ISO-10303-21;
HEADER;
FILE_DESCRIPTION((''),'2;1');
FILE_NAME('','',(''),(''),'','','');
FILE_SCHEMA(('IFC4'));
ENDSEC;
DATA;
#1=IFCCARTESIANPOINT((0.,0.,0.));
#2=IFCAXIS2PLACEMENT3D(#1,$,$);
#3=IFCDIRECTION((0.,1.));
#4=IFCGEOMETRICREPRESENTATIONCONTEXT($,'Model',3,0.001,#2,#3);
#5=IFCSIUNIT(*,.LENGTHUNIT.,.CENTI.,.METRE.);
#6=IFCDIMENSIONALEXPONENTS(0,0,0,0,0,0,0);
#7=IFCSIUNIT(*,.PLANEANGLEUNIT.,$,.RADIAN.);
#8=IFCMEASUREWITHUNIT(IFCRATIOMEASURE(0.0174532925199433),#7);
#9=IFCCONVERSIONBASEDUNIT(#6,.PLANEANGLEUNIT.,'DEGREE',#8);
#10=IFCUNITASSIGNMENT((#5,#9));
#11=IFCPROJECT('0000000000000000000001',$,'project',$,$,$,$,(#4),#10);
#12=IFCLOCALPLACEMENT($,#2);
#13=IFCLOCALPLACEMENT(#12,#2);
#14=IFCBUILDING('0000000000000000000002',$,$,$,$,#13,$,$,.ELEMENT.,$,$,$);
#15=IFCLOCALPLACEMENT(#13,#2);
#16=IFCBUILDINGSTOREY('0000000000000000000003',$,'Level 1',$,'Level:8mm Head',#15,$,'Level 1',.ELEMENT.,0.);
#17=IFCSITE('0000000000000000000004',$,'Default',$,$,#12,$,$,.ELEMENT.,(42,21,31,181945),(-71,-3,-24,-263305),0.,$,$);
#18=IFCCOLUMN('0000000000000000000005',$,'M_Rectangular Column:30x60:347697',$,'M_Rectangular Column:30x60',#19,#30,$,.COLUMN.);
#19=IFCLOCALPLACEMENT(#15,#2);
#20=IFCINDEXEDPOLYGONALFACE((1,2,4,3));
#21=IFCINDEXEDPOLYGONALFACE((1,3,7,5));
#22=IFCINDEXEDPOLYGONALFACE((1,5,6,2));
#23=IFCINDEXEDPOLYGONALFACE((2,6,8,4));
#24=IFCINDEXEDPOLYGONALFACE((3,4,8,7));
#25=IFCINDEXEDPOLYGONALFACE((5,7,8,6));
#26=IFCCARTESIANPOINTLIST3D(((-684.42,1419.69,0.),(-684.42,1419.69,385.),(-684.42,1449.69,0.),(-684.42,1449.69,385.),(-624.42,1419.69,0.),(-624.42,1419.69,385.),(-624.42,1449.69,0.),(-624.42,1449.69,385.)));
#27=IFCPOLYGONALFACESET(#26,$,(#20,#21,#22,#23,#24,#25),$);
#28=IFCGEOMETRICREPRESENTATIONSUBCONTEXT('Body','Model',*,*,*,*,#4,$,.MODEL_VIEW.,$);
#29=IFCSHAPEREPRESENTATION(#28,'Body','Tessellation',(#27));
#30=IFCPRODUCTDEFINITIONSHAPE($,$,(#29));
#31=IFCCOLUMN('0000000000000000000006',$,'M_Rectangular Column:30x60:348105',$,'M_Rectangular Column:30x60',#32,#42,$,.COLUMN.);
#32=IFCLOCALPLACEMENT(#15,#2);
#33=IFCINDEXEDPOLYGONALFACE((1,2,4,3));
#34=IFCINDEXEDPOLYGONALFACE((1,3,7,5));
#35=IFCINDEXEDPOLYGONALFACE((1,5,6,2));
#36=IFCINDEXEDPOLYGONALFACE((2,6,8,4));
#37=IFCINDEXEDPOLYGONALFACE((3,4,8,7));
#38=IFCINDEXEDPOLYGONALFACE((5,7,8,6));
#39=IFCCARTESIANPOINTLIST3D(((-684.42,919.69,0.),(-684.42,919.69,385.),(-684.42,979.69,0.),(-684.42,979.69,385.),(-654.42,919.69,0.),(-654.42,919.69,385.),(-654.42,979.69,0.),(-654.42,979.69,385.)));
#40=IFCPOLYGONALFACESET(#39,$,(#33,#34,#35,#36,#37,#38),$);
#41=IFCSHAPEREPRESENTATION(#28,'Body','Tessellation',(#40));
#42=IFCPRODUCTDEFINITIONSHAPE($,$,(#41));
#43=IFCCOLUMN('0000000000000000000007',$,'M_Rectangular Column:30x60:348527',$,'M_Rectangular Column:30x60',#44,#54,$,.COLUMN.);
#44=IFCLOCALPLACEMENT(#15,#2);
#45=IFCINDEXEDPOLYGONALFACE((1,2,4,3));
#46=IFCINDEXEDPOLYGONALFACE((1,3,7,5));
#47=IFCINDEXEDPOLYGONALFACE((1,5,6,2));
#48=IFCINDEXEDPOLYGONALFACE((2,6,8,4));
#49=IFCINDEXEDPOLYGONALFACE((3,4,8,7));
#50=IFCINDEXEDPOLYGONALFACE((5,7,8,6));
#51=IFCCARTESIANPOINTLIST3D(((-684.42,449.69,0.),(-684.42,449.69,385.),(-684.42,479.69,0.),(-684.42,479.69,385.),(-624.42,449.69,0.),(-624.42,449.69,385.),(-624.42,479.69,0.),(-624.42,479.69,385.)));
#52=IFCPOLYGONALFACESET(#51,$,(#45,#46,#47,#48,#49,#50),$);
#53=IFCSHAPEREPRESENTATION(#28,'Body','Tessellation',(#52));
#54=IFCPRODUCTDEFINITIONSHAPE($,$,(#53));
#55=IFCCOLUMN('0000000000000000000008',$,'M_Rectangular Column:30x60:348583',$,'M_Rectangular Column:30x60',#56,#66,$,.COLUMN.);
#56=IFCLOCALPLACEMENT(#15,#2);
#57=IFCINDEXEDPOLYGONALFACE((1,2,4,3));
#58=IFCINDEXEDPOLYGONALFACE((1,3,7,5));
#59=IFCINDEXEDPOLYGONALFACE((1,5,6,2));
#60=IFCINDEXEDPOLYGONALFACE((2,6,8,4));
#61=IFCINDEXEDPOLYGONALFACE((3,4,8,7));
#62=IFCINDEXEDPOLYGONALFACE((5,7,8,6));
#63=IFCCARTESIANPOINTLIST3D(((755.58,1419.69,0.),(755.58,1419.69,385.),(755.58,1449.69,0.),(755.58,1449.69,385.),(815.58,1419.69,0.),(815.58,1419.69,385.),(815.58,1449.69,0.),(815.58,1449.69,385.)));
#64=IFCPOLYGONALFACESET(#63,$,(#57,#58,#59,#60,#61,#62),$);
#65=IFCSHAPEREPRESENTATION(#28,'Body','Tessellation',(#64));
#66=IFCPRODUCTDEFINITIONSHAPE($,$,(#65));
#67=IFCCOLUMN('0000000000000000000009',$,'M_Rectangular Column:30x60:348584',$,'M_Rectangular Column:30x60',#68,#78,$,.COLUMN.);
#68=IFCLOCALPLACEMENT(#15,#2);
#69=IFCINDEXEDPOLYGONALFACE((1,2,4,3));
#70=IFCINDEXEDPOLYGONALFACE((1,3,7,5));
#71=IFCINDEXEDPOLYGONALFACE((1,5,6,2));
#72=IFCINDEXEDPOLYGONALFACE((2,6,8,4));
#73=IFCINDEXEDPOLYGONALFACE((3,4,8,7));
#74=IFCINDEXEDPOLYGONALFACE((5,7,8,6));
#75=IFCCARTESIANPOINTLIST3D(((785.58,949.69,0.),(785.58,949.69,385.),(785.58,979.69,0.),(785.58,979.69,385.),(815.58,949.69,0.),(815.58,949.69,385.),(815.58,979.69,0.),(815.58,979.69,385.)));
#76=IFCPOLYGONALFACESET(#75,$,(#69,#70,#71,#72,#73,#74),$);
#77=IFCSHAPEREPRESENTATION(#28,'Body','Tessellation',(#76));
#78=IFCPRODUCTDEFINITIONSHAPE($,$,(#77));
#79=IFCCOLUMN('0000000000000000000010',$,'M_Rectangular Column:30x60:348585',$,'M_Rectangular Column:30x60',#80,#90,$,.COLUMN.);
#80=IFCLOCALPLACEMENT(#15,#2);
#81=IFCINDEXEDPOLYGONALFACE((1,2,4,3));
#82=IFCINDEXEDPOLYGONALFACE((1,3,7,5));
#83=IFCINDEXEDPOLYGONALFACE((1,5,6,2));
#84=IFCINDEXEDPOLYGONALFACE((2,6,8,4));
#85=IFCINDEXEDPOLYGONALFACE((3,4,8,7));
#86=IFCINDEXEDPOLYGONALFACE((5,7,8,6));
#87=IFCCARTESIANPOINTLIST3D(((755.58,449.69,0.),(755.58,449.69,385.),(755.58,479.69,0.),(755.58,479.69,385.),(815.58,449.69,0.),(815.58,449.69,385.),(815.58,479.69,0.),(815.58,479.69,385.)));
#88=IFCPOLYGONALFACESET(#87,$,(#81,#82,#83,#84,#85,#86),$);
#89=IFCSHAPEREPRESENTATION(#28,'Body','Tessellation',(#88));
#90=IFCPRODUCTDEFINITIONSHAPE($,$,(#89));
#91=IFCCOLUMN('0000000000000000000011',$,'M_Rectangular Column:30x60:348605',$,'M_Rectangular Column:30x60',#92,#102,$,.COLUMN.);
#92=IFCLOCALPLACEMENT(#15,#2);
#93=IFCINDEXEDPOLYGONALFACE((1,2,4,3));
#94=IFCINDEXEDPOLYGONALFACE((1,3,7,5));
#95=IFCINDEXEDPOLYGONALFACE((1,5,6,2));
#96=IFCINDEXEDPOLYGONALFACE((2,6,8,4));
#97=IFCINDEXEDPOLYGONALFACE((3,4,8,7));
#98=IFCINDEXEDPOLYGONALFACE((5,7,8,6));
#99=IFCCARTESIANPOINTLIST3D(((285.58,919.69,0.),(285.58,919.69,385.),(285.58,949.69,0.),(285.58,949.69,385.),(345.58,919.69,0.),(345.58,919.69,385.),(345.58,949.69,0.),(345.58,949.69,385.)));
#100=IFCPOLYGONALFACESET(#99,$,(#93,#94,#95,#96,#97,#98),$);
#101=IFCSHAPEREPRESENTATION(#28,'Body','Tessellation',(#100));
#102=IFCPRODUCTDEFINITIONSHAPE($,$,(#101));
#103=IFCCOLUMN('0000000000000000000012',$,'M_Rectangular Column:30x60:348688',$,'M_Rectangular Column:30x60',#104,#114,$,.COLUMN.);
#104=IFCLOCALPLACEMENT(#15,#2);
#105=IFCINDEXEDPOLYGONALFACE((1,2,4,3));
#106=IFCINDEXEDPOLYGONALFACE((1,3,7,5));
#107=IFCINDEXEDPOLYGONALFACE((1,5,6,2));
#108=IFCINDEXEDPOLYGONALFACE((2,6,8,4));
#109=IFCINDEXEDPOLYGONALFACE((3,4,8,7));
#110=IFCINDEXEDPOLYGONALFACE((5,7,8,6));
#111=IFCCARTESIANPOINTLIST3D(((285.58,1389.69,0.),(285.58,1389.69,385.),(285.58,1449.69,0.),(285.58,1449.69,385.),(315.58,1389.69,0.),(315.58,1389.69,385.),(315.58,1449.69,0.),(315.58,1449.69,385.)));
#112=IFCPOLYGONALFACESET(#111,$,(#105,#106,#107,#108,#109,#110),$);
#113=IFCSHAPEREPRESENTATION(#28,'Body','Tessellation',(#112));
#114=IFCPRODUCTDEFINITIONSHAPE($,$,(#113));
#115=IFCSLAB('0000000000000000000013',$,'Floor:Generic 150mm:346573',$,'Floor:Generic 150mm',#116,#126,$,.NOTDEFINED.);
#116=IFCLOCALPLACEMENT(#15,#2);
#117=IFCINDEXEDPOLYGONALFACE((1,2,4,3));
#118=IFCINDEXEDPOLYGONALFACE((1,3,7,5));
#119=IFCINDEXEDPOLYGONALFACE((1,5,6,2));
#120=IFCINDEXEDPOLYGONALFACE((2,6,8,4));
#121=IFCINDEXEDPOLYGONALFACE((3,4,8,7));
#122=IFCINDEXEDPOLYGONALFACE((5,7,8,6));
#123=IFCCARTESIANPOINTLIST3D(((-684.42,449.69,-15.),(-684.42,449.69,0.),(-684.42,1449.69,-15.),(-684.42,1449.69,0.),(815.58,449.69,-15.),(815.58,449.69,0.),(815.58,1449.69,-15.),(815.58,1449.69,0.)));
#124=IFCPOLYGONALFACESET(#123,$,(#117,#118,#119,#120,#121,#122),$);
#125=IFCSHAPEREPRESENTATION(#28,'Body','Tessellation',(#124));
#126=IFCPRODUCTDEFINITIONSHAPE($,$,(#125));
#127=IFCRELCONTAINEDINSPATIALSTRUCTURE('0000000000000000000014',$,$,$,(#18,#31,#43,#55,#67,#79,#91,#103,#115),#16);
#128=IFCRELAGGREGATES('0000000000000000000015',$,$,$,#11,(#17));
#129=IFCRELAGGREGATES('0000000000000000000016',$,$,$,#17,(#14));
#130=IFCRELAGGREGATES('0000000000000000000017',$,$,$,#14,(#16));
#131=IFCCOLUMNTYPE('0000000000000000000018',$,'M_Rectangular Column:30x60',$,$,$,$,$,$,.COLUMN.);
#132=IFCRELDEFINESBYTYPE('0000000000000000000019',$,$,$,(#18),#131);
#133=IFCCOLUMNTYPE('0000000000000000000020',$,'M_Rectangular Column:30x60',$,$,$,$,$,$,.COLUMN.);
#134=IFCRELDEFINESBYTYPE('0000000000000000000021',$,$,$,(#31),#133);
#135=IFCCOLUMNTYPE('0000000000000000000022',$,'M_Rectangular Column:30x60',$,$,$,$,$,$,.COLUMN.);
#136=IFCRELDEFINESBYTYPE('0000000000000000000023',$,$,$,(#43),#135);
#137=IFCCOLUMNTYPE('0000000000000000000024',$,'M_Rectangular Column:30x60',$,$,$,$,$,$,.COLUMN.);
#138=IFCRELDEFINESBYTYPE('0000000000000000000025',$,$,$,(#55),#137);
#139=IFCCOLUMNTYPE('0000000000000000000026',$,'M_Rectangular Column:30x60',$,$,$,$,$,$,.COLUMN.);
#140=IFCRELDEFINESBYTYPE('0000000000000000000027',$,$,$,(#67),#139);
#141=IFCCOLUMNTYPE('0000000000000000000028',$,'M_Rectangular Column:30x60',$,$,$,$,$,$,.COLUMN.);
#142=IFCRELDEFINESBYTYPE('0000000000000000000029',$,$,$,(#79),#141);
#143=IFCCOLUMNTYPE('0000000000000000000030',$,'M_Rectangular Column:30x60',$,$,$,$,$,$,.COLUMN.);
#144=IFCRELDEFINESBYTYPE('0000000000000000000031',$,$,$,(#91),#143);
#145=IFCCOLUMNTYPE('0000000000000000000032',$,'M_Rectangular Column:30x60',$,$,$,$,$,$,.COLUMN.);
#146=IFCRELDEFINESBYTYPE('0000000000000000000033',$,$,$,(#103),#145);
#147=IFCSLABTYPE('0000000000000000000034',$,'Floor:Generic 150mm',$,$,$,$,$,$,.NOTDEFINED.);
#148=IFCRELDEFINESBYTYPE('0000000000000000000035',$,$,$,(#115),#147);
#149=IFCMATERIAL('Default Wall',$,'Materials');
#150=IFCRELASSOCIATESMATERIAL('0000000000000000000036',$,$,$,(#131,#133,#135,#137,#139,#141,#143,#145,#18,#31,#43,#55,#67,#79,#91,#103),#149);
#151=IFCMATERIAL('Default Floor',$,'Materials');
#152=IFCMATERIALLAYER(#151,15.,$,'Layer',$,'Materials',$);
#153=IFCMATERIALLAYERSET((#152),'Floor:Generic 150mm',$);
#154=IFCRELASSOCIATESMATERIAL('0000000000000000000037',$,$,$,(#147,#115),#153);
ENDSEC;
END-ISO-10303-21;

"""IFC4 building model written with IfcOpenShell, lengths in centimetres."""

from ifc_helpers import new_model, entity, si_unit, converted_unit, direction, frame, frame_2d, origin, origin_2d_with_axis, place, context, subcontext, project, spatial, rectangle, extrude, source, transform, mapped, material, layer, layer_set, layer_usage, material_profile, profile_set, profile_usage, type_object, type_shapes, element, save


model = new_model("IFC4")

# Units and contexts
model_context = context("Model", 3, precision=0.001, world=origin(), true_north=direction((0.0, 1.0)))
body_context = subcontext(model_context, "Body", "Model", "MODEL_VIEW")
ifc_project = project(units=[si_unit("LENGTHUNIT", "METRE", prefix="CENTI"), converted_unit("PLANEANGLEUNIT", "DEGREE", entity("IfcRatioMeasure", 0.0174532925199433), si_unit("PLANEANGLEUNIT", "RADIAN"), dimensions=[0, 0, 0, 0, 0, 0, 0])], contexts=[model_context])

# Site, building, storey
site_placement = place(None, origin())
site = spatial("IfcSite", under=ifc_project, at=site_placement, Name="Default", CompositionType="ELEMENT", RefLatitude=(42, 21, 31, 181945), RefLongitude=(-71, -3, -24, -263305), RefElevation=0.0)
building_placement = place(site_placement, origin())
building = spatial("IfcBuilding", under=site, at=building_placement, CompositionType="ELEMENT")
storey_placement = place(building_placement, origin())
storey = spatial("IfcBuildingStorey", under=building, at=storey_placement, Name="Level 1", ObjectType="Level:8mm Head", LongName="Level 1", CompositionType="ELEMENT", Elevation=0.0)

# Columns
ifc_material_1 = material(Name="Default Wall", Category="Materials")
ifc_material_profile = material_profile(ifc_material_1, rectangle(XDim=30.0, YDim=60.0, at=frame_2d((0.0, 0.0), x_axis=(1.0, 0.0))), Name="30x60")
ifc_profile_set = profile_set([ifc_material_profile], Name="30x60")
ifc_profile_usage_1 = profile_usage(ifc_profile_set)
column_type_1 = type_object("IfcColumnType", Name="M_Rectangular Column:30x60", PredefinedType="COLUMN", material=ifc_profile_set)
shared_shape_1 = source(origin(), body_context, "Body", "SweptSolid", [
    extrude(rectangle(XDim=30.0, YDim=60.0, at=frame_2d((0.0, 0.0), x_axis=(1.0, 0.0))), frame((-654.42, 1434.69, 0.0), z_axis=(0.0, 0.0, 1.0), x_axis=(0.0, -1.0, 0.0)), (0.0, 0.0, 1.0), 385.0),
])
type_shapes(column_type_1, [shared_shape_1])
column_1_placement = place(storey_placement, origin())
element("IfcColumn", 1, at=column_1_placement, inside=storey, type_object=column_type_1, material=ifc_profile_usage_1, Name="M_Rectangular Column:30x60:347697", ObjectType="M_Rectangular Column:30x60", PredefinedType="COLUMN", context=body_context, shape_type="MappedRepresentation", body=[
    mapped(shared_shape_1, transform((0.0, 0.0, 0.0), scale=1.0)),
])
ifc_profile_usage_2 = profile_usage(ifc_profile_set)
column_type_2 = type_object("IfcColumnType", Name="M_Rectangular Column:30x60", PredefinedType="COLUMN", material=ifc_profile_set)
shared_shape_2 = source(origin(), body_context, "Body", "SweptSolid", [
    extrude(rectangle(XDim=60.0, YDim=30.0, at=frame_2d((0.0, 0.0), x_axis=(1.0, 0.0))), frame((-669.42, 949.69, 0.0), z_axis=(0.0, 0.0, 1.0), x_axis=(0.0, -1.0, 0.0)), (0.0, 0.0, 1.0), 385.0),
])
type_shapes(column_type_2, [shared_shape_2])
column_2_placement = place(storey_placement, origin())
element("IfcColumn", 2, at=column_2_placement, inside=storey, type_object=column_type_2, material=ifc_profile_usage_2, Name="M_Rectangular Column:30x60:348105", ObjectType="M_Rectangular Column:30x60", PredefinedType="COLUMN", context=body_context, shape_type="MappedRepresentation", body=[
    mapped(shared_shape_2, transform((0.0, 0.0, 0.0), scale=1.0)),
])
ifc_profile_usage_3 = profile_usage(ifc_profile_set)
column_type_3 = type_object("IfcColumnType", Name="M_Rectangular Column:30x60", PredefinedType="COLUMN", material=ifc_profile_set)
shared_shape_3 = source(origin(), body_context, "Body", "SweptSolid", [
    extrude(rectangle(XDim=30.0, YDim=60.0, at=frame_2d((0.0, 0.0), x_axis=(1.0, 0.0))), frame((-654.42, 464.69, 0.0), z_axis=(0.0, 0.0, 1.0), x_axis=(0.0, -1.0, 0.0)), (0.0, 0.0, 1.0), 385.0),
])
type_shapes(column_type_3, [shared_shape_3])
column_3_placement = place(storey_placement, origin())
element("IfcColumn", 3, at=column_3_placement, inside=storey, type_object=column_type_3, material=ifc_profile_usage_3, Name="M_Rectangular Column:30x60:348527", ObjectType="M_Rectangular Column:30x60", PredefinedType="COLUMN", context=body_context, shape_type="MappedRepresentation", body=[
    mapped(shared_shape_3, transform((0.0, 0.0, 0.0), scale=1.0)),
])
ifc_profile_usage_4 = profile_usage(ifc_profile_set)
column_type_4 = type_object("IfcColumnType", Name="M_Rectangular Column:30x60", PredefinedType="COLUMN", material=ifc_profile_set)
shared_shape_4 = source(origin(), body_context, "Body", "SweptSolid", [
    extrude(rectangle(XDim=30.0, YDim=60.0, at=frame_2d((0.0, 0.0), x_axis=(1.0, 0.0))), frame((785.58, 1434.69, 0.0), z_axis=(0.0, 0.0, 1.0), x_axis=(0.0, -1.0, 0.0)), (0.0, 0.0, 1.0), 385.0),
])
type_shapes(column_type_4, [shared_shape_4])
column_4_placement = place(storey_placement, origin())
element("IfcColumn", 4, at=column_4_placement, inside=storey, type_object=column_type_4, material=ifc_profile_usage_4, Name="M_Rectangular Column:30x60:348583", ObjectType="M_Rectangular Column:30x60", PredefinedType="COLUMN", context=body_context, shape_type="MappedRepresentation", body=[
    mapped(shared_shape_4, transform((0.0, 0.0, 0.0), scale=1.0)),
])
ifc_profile_usage_5 = profile_usage(ifc_profile_set)
column_type_5 = type_object("IfcColumnType", Name="M_Rectangular Column:30x60", PredefinedType="COLUMN", material=ifc_profile_set)
shared_shape_5 = source(origin(), body_context, "Body", "SweptSolid", [
    extrude(rectangle(XDim=30.0, YDim=30.0, at=frame_2d((0.0, 0.0), x_axis=(1.0, 0.0))), frame((800.58, 964.69, 0.0), z_axis=(0.0, 0.0, 1.0), x_axis=(0.0, -1.0, 0.0)), (0.0, 0.0, 1.0), 385.0),
])
type_shapes(column_type_5, [shared_shape_5])
column_5_placement = place(storey_placement, origin())
element("IfcColumn", 5, at=column_5_placement, inside=storey, type_object=column_type_5, material=ifc_profile_usage_5, Name="M_Rectangular Column:30x60:348584", ObjectType="M_Rectangular Column:30x60", PredefinedType="COLUMN", context=body_context, shape_type="MappedRepresentation", body=[
    mapped(shared_shape_5, transform((0.0, 0.0, 0.0), scale=1.0)),
])
ifc_profile_usage_6 = profile_usage(ifc_profile_set)
column_type_6 = type_object("IfcColumnType", Name="M_Rectangular Column:30x60", PredefinedType="COLUMN", material=ifc_profile_set)
shared_shape_6 = source(origin(), body_context, "Body", "SweptSolid", [
    extrude(rectangle(XDim=30.0, YDim=60.0, at=frame_2d((0.0, 0.0), x_axis=(1.0, 0.0))), frame((785.58, 464.69, 0.0), z_axis=(0.0, 0.0, 1.0), x_axis=(0.0, -1.0, 0.0)), (0.0, 0.0, 1.0), 385.0),
])
type_shapes(column_type_6, [shared_shape_6])
column_6_placement = place(storey_placement, origin())
element("IfcColumn", 6, at=column_6_placement, inside=storey, type_object=column_type_6, material=ifc_profile_usage_6, Name="M_Rectangular Column:30x60:348585", ObjectType="M_Rectangular Column:30x60", PredefinedType="COLUMN", context=body_context, shape_type="MappedRepresentation", body=[
    mapped(shared_shape_6, transform((0.0, 0.0, 0.0), scale=1.0)),
])
ifc_profile_usage_7 = profile_usage(ifc_profile_set)
column_type_7 = type_object("IfcColumnType", Name="M_Rectangular Column:30x60", PredefinedType="COLUMN", material=ifc_profile_set)
shared_shape_7 = source(origin(), body_context, "Body", "SweptSolid", [
    extrude(rectangle(XDim=30.0, YDim=60.0, at=origin_2d_with_axis()), frame((315.58, 934.69, 0.0), z_axis=(0.0, 0.0, 1.0), x_axis=(0.0, -1.0, 0.0)), (0.0, 0.0, 1.0), 385.0),
])
type_shapes(column_type_7, [shared_shape_7])
column_7_placement = place(storey_placement, origin())
element("IfcColumn", 7, at=column_7_placement, inside=storey, type_object=column_type_7, material=ifc_profile_usage_7, Name="M_Rectangular Column:30x60:348605", ObjectType="M_Rectangular Column:30x60", PredefinedType="COLUMN", context=body_context, shape_type="MappedRepresentation", body=[
    mapped(shared_shape_7, transform((0.0, 0.0, 0.0), scale=1.0)),
])
ifc_profile_usage_8 = profile_usage(ifc_profile_set)
column_type_8 = type_object("IfcColumnType", Name="M_Rectangular Column:30x60", PredefinedType="COLUMN", material=ifc_profile_set)
shared_shape_8 = source(origin(), body_context, "Body", "SweptSolid", [
    extrude(rectangle(XDim=60.0, YDim=30.0, at=frame_2d((0.0, 0.0), x_axis=(1.0, 0.0))), frame((300.58, 1419.69, 0.0), z_axis=(0.0, 0.0, 1.0), x_axis=(0.0, -1.0, 0.0)), (0.0, 0.0, 1.0), 385.0),
])
type_shapes(column_type_8, [shared_shape_8])
column_8_placement = place(storey_placement, origin())
element("IfcColumn", 8, at=column_8_placement, inside=storey, type_object=column_type_8, material=ifc_profile_usage_8, Name="M_Rectangular Column:30x60:348688", ObjectType="M_Rectangular Column:30x60", PredefinedType="COLUMN", context=body_context, shape_type="MappedRepresentation", body=[
    mapped(shared_shape_8, transform((0.0, 0.0, 0.0), scale=1.0)),
])

# Slab
ifc_material_2 = material(Name="Default Floor", Category="Materials")
ifc_layer_1 = layer(ifc_material_2, 15.0, Name="Layer", Category="Materials")
ifc_layer_set_1 = layer_set([ifc_layer_1], Name="Floor:Generic 150mm")
ifc_layer_usage_1 = layer_usage(ifc_layer_set_1, "AXIS3", "POSITIVE", 0.0)
slab_type = type_object("IfcSlabType", Name="Floor:Generic 150mm", PredefinedType="NOTDEFINED", material=ifc_layer_set_1)
slab_placement = place(storey_placement, origin())
element("IfcSlab", 9, at=slab_placement, inside=storey, type_object=slab_type, material=ifc_layer_usage_1, Name="Floor:Generic 150mm:346573", ObjectType="Floor:Generic 150mm", PredefinedType="NOTDEFINED", context=body_context, shape_type="SweptSolid", body=[
    extrude(rectangle(XDim=1000.0, YDim=1500.0, at=origin_2d_with_axis()), frame((65.58, 949.69, 0.0), z_axis=(0.0, 0.0, -1.0), x_axis=(0.0, 1.0, 0.0)), (0.0, 0.0, 1.0), 15.0),
])

save(model, "model.ifc")
